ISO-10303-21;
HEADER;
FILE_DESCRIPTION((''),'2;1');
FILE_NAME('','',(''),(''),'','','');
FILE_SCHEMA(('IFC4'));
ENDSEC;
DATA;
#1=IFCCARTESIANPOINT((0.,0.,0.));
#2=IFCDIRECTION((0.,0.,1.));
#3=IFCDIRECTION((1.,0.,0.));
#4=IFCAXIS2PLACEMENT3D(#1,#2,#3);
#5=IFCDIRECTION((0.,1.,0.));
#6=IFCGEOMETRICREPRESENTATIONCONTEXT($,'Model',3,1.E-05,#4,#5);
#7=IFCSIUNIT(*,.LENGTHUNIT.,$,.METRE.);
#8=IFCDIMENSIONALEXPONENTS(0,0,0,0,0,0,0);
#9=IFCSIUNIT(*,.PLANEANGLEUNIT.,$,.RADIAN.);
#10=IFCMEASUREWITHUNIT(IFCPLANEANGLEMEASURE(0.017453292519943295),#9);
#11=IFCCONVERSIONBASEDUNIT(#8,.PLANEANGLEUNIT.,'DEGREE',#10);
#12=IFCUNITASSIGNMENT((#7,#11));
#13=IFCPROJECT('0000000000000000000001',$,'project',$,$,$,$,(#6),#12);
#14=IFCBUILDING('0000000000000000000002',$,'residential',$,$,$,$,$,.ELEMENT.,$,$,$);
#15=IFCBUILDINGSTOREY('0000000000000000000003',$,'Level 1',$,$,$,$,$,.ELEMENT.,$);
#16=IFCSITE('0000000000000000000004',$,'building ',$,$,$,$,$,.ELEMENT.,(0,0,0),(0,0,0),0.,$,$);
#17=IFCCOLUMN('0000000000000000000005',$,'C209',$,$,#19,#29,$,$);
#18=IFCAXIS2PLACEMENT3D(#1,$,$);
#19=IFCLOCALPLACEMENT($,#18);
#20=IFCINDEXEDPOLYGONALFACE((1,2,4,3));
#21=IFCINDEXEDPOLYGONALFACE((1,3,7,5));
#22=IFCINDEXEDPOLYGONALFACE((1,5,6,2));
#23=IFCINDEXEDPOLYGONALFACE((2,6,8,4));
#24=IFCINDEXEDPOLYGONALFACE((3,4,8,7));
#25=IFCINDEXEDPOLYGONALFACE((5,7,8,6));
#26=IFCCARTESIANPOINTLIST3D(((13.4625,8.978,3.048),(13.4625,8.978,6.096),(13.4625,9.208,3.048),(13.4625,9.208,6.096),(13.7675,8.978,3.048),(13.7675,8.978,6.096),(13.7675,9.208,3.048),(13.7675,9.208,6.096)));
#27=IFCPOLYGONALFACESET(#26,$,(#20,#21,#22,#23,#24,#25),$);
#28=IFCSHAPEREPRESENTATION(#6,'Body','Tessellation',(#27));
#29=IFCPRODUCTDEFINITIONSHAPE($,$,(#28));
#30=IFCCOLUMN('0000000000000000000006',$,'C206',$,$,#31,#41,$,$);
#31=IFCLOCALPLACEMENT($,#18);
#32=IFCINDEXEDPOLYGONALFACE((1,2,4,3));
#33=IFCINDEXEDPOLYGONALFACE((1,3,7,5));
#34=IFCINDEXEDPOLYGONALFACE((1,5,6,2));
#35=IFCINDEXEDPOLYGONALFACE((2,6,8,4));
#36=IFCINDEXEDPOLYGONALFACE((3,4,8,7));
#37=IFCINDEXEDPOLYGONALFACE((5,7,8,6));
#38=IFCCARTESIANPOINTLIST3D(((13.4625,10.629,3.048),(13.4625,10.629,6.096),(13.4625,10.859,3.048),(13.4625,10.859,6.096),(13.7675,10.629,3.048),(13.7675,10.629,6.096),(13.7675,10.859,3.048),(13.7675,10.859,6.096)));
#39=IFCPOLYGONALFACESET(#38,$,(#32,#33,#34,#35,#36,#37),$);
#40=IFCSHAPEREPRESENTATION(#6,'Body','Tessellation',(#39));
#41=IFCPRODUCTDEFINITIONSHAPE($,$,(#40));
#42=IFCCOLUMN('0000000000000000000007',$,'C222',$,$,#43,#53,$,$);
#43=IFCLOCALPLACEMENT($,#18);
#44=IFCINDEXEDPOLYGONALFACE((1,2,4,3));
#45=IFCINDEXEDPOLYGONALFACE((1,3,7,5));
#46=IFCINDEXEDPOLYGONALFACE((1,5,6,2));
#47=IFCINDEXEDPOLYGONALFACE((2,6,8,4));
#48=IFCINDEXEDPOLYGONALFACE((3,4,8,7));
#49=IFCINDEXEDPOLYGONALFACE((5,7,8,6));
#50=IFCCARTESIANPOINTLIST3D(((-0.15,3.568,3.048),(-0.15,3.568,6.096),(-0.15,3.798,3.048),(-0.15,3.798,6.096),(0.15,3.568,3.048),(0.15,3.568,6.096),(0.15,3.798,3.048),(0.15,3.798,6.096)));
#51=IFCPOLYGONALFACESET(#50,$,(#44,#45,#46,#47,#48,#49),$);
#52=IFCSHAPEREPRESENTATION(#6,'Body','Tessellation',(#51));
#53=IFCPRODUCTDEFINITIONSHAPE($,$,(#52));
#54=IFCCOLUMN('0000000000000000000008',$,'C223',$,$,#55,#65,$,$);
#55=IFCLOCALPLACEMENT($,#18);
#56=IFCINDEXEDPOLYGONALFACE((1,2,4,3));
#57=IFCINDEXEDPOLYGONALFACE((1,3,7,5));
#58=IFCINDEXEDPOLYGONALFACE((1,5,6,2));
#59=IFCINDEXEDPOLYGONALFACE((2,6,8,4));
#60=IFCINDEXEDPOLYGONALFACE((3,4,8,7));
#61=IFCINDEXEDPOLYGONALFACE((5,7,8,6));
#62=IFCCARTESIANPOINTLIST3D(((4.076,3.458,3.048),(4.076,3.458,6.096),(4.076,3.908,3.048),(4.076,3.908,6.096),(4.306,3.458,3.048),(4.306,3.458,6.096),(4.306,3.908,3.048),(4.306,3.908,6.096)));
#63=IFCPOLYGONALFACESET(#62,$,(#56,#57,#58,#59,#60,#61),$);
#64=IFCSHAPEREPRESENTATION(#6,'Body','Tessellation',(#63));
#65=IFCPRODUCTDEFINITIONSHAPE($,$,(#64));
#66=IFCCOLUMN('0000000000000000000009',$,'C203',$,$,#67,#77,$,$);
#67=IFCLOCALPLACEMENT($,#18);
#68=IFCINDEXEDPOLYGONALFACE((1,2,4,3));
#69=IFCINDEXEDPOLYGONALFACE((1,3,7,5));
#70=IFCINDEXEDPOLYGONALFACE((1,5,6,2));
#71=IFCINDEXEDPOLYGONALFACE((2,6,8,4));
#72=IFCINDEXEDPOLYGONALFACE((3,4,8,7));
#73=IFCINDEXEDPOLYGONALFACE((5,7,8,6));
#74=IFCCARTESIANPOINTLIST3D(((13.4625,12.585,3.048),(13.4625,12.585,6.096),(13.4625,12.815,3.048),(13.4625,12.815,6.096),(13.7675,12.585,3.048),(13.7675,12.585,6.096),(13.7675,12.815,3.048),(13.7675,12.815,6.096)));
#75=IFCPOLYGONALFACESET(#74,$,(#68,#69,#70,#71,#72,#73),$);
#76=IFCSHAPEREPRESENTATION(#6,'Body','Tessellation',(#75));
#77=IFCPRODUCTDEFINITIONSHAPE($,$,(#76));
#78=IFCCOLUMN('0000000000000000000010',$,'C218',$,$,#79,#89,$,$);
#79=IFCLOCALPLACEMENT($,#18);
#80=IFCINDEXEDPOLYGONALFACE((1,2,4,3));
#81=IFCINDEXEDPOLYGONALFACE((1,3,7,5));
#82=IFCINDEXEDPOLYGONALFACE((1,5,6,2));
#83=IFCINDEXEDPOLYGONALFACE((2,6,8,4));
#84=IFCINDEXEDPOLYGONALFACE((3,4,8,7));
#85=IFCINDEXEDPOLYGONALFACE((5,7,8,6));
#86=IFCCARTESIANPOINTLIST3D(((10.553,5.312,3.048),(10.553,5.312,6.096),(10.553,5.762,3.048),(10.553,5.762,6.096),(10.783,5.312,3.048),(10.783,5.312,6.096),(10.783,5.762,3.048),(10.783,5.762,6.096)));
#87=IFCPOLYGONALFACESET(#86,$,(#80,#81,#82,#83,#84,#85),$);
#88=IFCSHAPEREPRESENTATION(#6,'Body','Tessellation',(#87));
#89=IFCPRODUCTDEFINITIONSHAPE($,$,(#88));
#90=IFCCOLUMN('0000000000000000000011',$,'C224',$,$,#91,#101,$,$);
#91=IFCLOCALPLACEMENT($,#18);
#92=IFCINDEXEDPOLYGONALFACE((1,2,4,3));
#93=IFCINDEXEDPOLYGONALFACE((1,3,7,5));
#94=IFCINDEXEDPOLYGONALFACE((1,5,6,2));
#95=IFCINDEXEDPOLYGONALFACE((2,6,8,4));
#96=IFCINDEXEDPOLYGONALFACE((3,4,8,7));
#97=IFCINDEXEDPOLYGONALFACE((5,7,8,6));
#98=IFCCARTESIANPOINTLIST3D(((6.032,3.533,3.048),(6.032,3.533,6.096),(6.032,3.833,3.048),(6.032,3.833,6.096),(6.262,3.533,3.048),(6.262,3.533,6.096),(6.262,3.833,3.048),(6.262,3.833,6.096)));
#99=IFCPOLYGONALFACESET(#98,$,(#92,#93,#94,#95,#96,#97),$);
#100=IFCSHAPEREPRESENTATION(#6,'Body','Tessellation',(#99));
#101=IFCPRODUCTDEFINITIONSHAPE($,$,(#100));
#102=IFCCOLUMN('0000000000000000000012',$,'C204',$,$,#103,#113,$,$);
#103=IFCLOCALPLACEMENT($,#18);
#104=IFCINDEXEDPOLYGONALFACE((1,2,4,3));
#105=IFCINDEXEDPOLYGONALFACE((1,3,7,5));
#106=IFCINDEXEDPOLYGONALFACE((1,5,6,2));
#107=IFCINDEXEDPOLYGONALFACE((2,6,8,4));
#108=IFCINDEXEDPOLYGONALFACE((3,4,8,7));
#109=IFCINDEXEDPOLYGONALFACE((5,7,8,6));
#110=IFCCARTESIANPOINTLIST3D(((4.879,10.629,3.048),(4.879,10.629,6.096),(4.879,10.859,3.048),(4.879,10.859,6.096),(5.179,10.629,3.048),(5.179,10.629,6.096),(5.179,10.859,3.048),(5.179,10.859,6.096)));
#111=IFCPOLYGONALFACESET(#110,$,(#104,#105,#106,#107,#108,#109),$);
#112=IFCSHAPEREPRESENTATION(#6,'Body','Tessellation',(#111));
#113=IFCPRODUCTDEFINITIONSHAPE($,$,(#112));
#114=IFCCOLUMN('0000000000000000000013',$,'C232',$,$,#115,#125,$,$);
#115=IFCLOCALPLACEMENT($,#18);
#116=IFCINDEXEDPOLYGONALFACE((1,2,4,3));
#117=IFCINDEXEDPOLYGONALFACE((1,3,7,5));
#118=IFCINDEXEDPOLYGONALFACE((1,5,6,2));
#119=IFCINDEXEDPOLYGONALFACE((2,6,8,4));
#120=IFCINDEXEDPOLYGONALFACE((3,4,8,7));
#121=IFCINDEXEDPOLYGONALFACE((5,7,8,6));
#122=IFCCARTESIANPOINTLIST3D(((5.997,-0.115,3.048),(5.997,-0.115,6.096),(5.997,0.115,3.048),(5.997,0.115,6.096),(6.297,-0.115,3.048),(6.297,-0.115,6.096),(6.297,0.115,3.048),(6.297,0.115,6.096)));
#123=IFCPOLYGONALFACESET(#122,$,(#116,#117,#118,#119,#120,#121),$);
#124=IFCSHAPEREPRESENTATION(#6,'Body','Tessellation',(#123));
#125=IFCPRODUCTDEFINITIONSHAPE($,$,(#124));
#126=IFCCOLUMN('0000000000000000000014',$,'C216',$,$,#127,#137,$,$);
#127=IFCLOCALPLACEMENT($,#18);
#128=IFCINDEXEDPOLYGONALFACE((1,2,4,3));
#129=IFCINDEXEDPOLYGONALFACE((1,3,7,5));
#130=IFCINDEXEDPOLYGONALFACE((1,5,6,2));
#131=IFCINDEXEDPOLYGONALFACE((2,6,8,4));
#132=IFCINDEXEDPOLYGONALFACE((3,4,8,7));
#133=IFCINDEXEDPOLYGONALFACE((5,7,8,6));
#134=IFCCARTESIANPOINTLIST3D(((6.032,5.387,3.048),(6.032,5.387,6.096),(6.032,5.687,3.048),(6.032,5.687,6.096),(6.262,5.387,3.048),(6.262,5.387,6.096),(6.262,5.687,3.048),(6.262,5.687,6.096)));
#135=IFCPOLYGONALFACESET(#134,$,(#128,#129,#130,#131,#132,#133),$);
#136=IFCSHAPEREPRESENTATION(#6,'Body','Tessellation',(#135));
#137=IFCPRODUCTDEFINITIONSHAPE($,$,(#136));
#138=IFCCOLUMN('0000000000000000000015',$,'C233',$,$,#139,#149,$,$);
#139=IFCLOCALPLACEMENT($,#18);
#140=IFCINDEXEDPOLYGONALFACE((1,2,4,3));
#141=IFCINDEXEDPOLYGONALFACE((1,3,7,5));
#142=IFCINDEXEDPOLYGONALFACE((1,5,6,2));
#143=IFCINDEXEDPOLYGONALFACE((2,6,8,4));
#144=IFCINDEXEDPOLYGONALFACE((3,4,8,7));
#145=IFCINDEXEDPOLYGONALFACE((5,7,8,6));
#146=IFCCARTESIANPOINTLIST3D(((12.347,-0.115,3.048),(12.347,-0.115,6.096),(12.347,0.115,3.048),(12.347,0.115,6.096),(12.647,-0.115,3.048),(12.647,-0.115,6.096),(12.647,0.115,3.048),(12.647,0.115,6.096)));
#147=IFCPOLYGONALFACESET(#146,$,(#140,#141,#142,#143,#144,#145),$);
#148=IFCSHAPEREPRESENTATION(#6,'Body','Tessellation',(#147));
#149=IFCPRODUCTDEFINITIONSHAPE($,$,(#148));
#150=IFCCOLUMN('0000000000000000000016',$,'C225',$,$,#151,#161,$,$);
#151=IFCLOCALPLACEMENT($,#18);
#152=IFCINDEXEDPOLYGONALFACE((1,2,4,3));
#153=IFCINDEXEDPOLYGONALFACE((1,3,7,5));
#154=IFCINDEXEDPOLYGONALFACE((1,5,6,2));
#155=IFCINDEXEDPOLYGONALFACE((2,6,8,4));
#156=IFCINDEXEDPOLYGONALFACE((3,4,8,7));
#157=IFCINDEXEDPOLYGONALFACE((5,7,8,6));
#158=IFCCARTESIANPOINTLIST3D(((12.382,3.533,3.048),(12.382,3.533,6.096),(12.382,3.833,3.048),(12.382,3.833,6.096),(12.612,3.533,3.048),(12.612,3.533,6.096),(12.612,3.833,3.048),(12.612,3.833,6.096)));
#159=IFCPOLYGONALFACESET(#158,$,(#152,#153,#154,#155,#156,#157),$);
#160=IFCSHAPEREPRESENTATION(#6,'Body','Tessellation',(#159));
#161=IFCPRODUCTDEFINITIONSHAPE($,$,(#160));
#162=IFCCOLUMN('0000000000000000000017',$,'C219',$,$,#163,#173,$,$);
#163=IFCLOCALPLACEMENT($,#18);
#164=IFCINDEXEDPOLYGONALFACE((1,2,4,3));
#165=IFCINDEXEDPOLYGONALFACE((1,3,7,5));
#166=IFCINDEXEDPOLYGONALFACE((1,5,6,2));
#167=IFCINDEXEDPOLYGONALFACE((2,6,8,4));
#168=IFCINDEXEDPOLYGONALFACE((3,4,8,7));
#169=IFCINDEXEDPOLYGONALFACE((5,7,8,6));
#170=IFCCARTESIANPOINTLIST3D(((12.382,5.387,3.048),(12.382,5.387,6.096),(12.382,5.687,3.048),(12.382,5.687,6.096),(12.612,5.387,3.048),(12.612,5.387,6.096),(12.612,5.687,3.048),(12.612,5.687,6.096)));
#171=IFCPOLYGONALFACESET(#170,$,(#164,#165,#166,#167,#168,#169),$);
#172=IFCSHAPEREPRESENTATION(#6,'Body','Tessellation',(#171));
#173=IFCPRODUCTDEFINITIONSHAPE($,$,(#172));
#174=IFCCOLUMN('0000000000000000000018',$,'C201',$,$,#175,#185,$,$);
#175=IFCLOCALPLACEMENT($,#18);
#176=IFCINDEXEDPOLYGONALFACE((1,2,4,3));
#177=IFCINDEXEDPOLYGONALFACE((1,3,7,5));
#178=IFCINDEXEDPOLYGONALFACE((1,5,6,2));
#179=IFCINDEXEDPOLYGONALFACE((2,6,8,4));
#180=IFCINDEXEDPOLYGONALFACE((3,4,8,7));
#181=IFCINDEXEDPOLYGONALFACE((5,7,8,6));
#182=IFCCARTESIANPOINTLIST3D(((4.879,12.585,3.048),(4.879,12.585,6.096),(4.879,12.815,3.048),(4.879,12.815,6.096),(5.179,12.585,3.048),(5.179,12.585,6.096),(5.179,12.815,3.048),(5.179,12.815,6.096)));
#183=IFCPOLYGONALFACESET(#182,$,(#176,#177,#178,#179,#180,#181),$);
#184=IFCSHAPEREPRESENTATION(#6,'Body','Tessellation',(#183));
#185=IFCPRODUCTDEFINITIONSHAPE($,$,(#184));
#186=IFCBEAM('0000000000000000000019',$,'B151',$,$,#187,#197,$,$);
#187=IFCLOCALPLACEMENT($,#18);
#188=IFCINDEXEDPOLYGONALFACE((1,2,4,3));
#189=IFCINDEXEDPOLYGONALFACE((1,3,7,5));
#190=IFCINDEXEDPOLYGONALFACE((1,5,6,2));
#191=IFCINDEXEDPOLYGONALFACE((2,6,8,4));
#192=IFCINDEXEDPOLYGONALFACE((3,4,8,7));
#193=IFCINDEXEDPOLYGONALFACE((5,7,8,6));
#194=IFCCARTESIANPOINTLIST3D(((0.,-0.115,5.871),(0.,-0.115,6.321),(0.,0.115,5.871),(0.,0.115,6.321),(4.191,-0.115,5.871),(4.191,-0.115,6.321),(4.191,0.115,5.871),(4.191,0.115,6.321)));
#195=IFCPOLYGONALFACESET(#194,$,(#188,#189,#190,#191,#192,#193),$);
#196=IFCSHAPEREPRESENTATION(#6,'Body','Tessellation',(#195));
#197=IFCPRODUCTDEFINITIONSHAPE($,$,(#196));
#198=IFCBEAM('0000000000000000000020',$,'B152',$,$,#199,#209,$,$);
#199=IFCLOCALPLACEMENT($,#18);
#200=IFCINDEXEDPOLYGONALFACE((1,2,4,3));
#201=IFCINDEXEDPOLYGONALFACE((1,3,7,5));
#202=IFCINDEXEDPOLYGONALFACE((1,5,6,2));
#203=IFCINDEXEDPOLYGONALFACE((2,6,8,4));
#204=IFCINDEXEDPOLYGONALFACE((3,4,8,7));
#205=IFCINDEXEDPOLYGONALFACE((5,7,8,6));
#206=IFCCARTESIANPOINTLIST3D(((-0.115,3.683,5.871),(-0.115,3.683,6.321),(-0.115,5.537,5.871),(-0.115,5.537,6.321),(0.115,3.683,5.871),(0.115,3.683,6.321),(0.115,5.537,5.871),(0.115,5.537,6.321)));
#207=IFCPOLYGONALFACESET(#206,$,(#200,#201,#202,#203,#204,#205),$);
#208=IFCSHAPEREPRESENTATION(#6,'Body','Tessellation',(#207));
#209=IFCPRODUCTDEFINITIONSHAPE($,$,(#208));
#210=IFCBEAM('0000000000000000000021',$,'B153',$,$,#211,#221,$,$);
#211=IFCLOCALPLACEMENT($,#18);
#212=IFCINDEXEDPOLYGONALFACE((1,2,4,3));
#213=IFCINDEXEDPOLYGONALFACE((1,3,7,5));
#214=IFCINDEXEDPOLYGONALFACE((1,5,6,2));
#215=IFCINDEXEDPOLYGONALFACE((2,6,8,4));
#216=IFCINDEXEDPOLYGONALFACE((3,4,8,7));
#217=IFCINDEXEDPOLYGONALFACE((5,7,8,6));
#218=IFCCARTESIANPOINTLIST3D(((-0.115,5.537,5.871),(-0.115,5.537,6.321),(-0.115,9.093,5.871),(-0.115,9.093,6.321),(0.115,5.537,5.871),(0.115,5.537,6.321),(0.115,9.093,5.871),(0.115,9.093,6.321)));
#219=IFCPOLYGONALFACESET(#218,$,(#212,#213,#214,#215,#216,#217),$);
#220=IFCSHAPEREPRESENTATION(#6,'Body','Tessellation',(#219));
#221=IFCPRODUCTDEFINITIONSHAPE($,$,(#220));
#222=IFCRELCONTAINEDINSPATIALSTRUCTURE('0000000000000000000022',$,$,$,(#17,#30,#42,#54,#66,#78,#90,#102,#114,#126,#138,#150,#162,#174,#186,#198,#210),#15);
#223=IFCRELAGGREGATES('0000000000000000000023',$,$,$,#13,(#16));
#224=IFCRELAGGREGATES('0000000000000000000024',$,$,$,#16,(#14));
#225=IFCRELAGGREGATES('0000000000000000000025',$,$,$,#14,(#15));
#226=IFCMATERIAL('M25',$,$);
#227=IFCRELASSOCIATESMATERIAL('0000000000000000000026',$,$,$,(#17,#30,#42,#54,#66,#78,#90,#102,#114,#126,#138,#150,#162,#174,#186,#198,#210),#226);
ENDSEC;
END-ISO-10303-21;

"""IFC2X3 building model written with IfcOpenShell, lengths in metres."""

from ifc_helpers import new_model, entity, si_unit, converted_unit, direction, frame, frame_2d, origin_with_axes, place, context, project, spatial, rectangle, extrude, material, element, save


model = new_model("IFC2X3")

# Units and contexts
model_context = context("Model", 3, precision=1e-05, world=origin_with_axes(), true_north=direction((0.0, 1.0, 0.0)))
ifc_project = project(units=[si_unit("LENGTHUNIT", "METRE"), converted_unit("PLANEANGLEUNIT", "DEGREE", entity("IfcPlaneAngleMeasure", 0.017453292519943295), si_unit("PLANEANGLEUNIT", "RADIAN"), dimensions=[0, 0, 0, 0, 0, 0, 0])], contexts=[model_context])

# Site, building, storey
site = spatial("IfcSite", under=ifc_project, Name="building ", CompositionType="ELEMENT", RefLatitude=(0, 0, 0), RefLongitude=(0, 0, 0), RefElevation=0.0)
building = spatial("IfcBuilding", under=site, Name="residential", CompositionType="ELEMENT")
storey = spatial("IfcBuildingStorey", under=building, Name="Level 1", CompositionType="ELEMENT")

# Columns
ifc_material = material(Name="M25")
placement = place(None, origin_with_axes())
element("IfcColumn", 1, at=placement, inside=storey, material=ifc_material, Name="C209", context=model_context, shape_type="SweptSolid", body=[
    extrude(rectangle(XDim=0.305, YDim=0.23, at=frame_2d((0.0, 0.0), x_axis=(1.0, 0.0, 0.0))), frame((13.615, 9.093, 3.048), z_axis=(0.0, 0.0, 1.0), x_axis=(1.0, 0.0, 0.0)), (0.0, 0.0, 1.0), 3.048),
])
element("IfcColumn", 2, at=placement, inside=storey, material=ifc_material, Name="C206", context=model_context, shape_type="SweptSolid", body=[
    extrude(rectangle(XDim=0.305, YDim=0.23, at=frame_2d((0.0, 0.0), x_axis=(1.0, 0.0, 0.0))), frame((13.615, 10.744, 3.048), z_axis=(0.0, 0.0, 1.0), x_axis=(1.0, 0.0, 0.0)), (0.0, 0.0, 1.0), 3.048),
])
element("IfcColumn", 3, at=placement, inside=storey, material=ifc_material, Name="C222", context=model_context, shape_type="SweptSolid", body=[
    extrude(rectangle(XDim=0.3, YDim=0.23, at=frame_2d((0.0, 0.0), x_axis=(1.0, 0.0, 0.0))), frame((0.0, 3.683, 3.048), z_axis=(0.0, 0.0, 1.0), x_axis=(1.0, 0.0, 0.0)), (0.0, 0.0, 1.0), 3.048),
])
element("IfcColumn", 4, at=placement, inside=storey, material=ifc_material, Name="C223", context=model_context, shape_type="SweptSolid", body=[
    extrude(rectangle(XDim=0.23, YDim=0.45, at=frame_2d((0.0, 0.0), x_axis=(1.0, 0.0, 0.0))), frame((4.191, 3.683, 3.048), z_axis=(0.0, 0.0, 1.0), x_axis=(1.0, 0.0, 0.0)), (0.0, 0.0, 1.0), 3.048),
])
element("IfcColumn", 5, at=placement, inside=storey, material=ifc_material, Name="C203", context=model_context, shape_type="SweptSolid", body=[
    extrude(rectangle(XDim=0.305, YDim=0.23, at=frame_2d((0.0, 0.0), x_axis=(1.0, 0.0, 0.0))), frame((13.615, 12.7, 3.048), z_axis=(0.0, 0.0, 1.0), x_axis=(1.0, 0.0, 0.0)), (0.0, 0.0, 1.0), 3.048),
])
element("IfcColumn", 6, at=placement, inside=storey, material=ifc_material, Name="C218", context=model_context, shape_type="SweptSolid", body=[
    extrude(rectangle(XDim=0.23, YDim=0.45, at=frame_2d((0.0, 0.0), x_axis=(1.0, 0.0, 0.0))), frame((10.668, 5.537, 3.048), z_axis=(0.0, 0.0, 1.0), x_axis=(1.0, 0.0, 0.0)), (0.0, 0.0, 1.0), 3.048),
])
element("IfcColumn", 7, at=placement, inside=storey, material=ifc_material, Name="C224", context=model_context, shape_type="SweptSolid", body=[
    extrude(rectangle(XDim=0.23, YDim=0.3, at=frame_2d((0.0, 0.0), x_axis=(1.0, 0.0, 0.0))), frame((6.147, 3.683, 3.048), z_axis=(0.0, 0.0, 1.0), x_axis=(1.0, 0.0, 0.0)), (0.0, 0.0, 1.0), 3.048),
])
element("IfcColumn", 8, at=placement, inside=storey, material=ifc_material, Name="C204", context=model_context, shape_type="SweptSolid", body=[
    extrude(rectangle(XDim=0.3, YDim=0.23, at=frame_2d((0.0, 0.0), x_axis=(1.0, 0.0, 0.0))), frame((5.029, 10.744, 3.048), z_axis=(0.0, 0.0, 1.0), x_axis=(1.0, 0.0, 0.0)), (0.0, 0.0, 1.0), 3.048),
])
element("IfcColumn", 9, at=placement, inside=storey, material=ifc_material, Name="C232", context=model_context, shape_type="SweptSolid", body=[
    extrude(rectangle(XDim=0.3, YDim=0.23, at=frame_2d((0.0, 0.0), x_axis=(1.0, 0.0, 0.0))), frame((6.147, 0.0, 3.048), z_axis=(0.0, 0.0, 1.0), x_axis=(1.0, 0.0, 0.0)), (0.0, 0.0, 1.0), 3.048),
])
element("IfcColumn", 10, at=placement, inside=storey, material=ifc_material, Name="C216", context=model_context, shape_type="SweptSolid", body=[
    extrude(rectangle(XDim=0.23, YDim=0.3, at=frame_2d((0.0, 0.0), x_axis=(1.0, 0.0, 0.0))), frame((6.147, 5.537, 3.048), z_axis=(0.0, 0.0, 1.0), x_axis=(1.0, 0.0, 0.0)), (0.0, 0.0, 1.0), 3.048),
])
element("IfcColumn", 11, at=placement, inside=storey, material=ifc_material, Name="C233", context=model_context, shape_type="SweptSolid", body=[
    extrude(rectangle(XDim=0.3, YDim=0.23, at=frame_2d((0.0, 0.0), x_axis=(1.0, 0.0, 0.0))), frame((12.497, 0.0, 3.048), z_axis=(0.0, 0.0, 1.0), x_axis=(1.0, 0.0, 0.0)), (0.0, 0.0, 1.0), 3.048),
])
element("IfcColumn", 12, at=placement, inside=storey, material=ifc_material, Name="C225", context=model_context, shape_type="SweptSolid", body=[
    extrude(rectangle(XDim=0.23, YDim=0.3, at=frame_2d((0.0, 0.0), x_axis=(1.0, 0.0, 0.0))), frame((12.497, 3.683, 3.048), z_axis=(0.0, 0.0, 1.0), x_axis=(1.0, 0.0, 0.0)), (0.0, 0.0, 1.0), 3.048),
])
element("IfcColumn", 13, at=placement, inside=storey, material=ifc_material, Name="C219", context=model_context, shape_type="SweptSolid", body=[
    extrude(rectangle(XDim=0.23, YDim=0.3, at=frame_2d((0.0, 0.0), x_axis=(1.0, 0.0, 0.0))), frame((12.497, 5.537, 3.048), z_axis=(0.0, 0.0, 1.0), x_axis=(1.0, 0.0, 0.0)), (0.0, 0.0, 1.0), 3.048),
])
element("IfcColumn", 14, at=placement, inside=storey, material=ifc_material, Name="C201", context=model_context, shape_type="SweptSolid", body=[
    extrude(rectangle(XDim=0.3, YDim=0.23, at=frame_2d((0.0, 0.0), x_axis=(1.0, 0.0, 0.0))), frame((5.029, 12.7, 3.048), z_axis=(0.0, 0.0, 1.0), x_axis=(1.0, 0.0, 0.0)), (0.0, 0.0, 1.0), 3.048),
])

# Beams
element("IfcBeam", 15, at=placement, inside=storey, material=ifc_material, Name="B151", context=model_context, shape_type="SweptSolid", body=[
    extrude(rectangle(XDim=0.23, YDim=0.45, at=frame_2d((0.0, 0.0), x_axis=(0.0, 1.0, 0.0))), frame((0.0, 0.0, 6.096), z_axis=(1.0, 0.0, 0.0), x_axis=(0.0, 0.0, -1.0)), (0.0, 0.0, 1.0), 4.191),
])
element("IfcBeam", 16, at=placement, inside=storey, material=ifc_material, Name="B152", context=model_context, shape_type="SweptSolid", body=[
    extrude(rectangle(XDim=0.23, YDim=0.45, at=frame_2d((0.0, 0.0), x_axis=(0.0, 1.0, 0.0))), frame((0.0, 3.683, 6.096), z_axis=(0.0, 1.0, 0.0), x_axis=(0.0, 0.0, -1.0)), (0.0, 0.0, 1.0), 1.854),
])
element("IfcBeam", 17, at=placement, inside=storey, material=ifc_material, Name="B153", context=model_context, shape_type="SweptSolid", body=[
    extrude(rectangle(XDim=0.23, YDim=0.45, at=frame_2d((0.0, 0.0), x_axis=(0.0, 1.0, 0.0))), frame((0.0, 5.537, 6.096), z_axis=(0.0, 1.0, 0.0), x_axis=(0.0, 0.0, -1.0)), (0.0, 0.0, 1.0), 3.556),
])

save(model, "model.ifc")
